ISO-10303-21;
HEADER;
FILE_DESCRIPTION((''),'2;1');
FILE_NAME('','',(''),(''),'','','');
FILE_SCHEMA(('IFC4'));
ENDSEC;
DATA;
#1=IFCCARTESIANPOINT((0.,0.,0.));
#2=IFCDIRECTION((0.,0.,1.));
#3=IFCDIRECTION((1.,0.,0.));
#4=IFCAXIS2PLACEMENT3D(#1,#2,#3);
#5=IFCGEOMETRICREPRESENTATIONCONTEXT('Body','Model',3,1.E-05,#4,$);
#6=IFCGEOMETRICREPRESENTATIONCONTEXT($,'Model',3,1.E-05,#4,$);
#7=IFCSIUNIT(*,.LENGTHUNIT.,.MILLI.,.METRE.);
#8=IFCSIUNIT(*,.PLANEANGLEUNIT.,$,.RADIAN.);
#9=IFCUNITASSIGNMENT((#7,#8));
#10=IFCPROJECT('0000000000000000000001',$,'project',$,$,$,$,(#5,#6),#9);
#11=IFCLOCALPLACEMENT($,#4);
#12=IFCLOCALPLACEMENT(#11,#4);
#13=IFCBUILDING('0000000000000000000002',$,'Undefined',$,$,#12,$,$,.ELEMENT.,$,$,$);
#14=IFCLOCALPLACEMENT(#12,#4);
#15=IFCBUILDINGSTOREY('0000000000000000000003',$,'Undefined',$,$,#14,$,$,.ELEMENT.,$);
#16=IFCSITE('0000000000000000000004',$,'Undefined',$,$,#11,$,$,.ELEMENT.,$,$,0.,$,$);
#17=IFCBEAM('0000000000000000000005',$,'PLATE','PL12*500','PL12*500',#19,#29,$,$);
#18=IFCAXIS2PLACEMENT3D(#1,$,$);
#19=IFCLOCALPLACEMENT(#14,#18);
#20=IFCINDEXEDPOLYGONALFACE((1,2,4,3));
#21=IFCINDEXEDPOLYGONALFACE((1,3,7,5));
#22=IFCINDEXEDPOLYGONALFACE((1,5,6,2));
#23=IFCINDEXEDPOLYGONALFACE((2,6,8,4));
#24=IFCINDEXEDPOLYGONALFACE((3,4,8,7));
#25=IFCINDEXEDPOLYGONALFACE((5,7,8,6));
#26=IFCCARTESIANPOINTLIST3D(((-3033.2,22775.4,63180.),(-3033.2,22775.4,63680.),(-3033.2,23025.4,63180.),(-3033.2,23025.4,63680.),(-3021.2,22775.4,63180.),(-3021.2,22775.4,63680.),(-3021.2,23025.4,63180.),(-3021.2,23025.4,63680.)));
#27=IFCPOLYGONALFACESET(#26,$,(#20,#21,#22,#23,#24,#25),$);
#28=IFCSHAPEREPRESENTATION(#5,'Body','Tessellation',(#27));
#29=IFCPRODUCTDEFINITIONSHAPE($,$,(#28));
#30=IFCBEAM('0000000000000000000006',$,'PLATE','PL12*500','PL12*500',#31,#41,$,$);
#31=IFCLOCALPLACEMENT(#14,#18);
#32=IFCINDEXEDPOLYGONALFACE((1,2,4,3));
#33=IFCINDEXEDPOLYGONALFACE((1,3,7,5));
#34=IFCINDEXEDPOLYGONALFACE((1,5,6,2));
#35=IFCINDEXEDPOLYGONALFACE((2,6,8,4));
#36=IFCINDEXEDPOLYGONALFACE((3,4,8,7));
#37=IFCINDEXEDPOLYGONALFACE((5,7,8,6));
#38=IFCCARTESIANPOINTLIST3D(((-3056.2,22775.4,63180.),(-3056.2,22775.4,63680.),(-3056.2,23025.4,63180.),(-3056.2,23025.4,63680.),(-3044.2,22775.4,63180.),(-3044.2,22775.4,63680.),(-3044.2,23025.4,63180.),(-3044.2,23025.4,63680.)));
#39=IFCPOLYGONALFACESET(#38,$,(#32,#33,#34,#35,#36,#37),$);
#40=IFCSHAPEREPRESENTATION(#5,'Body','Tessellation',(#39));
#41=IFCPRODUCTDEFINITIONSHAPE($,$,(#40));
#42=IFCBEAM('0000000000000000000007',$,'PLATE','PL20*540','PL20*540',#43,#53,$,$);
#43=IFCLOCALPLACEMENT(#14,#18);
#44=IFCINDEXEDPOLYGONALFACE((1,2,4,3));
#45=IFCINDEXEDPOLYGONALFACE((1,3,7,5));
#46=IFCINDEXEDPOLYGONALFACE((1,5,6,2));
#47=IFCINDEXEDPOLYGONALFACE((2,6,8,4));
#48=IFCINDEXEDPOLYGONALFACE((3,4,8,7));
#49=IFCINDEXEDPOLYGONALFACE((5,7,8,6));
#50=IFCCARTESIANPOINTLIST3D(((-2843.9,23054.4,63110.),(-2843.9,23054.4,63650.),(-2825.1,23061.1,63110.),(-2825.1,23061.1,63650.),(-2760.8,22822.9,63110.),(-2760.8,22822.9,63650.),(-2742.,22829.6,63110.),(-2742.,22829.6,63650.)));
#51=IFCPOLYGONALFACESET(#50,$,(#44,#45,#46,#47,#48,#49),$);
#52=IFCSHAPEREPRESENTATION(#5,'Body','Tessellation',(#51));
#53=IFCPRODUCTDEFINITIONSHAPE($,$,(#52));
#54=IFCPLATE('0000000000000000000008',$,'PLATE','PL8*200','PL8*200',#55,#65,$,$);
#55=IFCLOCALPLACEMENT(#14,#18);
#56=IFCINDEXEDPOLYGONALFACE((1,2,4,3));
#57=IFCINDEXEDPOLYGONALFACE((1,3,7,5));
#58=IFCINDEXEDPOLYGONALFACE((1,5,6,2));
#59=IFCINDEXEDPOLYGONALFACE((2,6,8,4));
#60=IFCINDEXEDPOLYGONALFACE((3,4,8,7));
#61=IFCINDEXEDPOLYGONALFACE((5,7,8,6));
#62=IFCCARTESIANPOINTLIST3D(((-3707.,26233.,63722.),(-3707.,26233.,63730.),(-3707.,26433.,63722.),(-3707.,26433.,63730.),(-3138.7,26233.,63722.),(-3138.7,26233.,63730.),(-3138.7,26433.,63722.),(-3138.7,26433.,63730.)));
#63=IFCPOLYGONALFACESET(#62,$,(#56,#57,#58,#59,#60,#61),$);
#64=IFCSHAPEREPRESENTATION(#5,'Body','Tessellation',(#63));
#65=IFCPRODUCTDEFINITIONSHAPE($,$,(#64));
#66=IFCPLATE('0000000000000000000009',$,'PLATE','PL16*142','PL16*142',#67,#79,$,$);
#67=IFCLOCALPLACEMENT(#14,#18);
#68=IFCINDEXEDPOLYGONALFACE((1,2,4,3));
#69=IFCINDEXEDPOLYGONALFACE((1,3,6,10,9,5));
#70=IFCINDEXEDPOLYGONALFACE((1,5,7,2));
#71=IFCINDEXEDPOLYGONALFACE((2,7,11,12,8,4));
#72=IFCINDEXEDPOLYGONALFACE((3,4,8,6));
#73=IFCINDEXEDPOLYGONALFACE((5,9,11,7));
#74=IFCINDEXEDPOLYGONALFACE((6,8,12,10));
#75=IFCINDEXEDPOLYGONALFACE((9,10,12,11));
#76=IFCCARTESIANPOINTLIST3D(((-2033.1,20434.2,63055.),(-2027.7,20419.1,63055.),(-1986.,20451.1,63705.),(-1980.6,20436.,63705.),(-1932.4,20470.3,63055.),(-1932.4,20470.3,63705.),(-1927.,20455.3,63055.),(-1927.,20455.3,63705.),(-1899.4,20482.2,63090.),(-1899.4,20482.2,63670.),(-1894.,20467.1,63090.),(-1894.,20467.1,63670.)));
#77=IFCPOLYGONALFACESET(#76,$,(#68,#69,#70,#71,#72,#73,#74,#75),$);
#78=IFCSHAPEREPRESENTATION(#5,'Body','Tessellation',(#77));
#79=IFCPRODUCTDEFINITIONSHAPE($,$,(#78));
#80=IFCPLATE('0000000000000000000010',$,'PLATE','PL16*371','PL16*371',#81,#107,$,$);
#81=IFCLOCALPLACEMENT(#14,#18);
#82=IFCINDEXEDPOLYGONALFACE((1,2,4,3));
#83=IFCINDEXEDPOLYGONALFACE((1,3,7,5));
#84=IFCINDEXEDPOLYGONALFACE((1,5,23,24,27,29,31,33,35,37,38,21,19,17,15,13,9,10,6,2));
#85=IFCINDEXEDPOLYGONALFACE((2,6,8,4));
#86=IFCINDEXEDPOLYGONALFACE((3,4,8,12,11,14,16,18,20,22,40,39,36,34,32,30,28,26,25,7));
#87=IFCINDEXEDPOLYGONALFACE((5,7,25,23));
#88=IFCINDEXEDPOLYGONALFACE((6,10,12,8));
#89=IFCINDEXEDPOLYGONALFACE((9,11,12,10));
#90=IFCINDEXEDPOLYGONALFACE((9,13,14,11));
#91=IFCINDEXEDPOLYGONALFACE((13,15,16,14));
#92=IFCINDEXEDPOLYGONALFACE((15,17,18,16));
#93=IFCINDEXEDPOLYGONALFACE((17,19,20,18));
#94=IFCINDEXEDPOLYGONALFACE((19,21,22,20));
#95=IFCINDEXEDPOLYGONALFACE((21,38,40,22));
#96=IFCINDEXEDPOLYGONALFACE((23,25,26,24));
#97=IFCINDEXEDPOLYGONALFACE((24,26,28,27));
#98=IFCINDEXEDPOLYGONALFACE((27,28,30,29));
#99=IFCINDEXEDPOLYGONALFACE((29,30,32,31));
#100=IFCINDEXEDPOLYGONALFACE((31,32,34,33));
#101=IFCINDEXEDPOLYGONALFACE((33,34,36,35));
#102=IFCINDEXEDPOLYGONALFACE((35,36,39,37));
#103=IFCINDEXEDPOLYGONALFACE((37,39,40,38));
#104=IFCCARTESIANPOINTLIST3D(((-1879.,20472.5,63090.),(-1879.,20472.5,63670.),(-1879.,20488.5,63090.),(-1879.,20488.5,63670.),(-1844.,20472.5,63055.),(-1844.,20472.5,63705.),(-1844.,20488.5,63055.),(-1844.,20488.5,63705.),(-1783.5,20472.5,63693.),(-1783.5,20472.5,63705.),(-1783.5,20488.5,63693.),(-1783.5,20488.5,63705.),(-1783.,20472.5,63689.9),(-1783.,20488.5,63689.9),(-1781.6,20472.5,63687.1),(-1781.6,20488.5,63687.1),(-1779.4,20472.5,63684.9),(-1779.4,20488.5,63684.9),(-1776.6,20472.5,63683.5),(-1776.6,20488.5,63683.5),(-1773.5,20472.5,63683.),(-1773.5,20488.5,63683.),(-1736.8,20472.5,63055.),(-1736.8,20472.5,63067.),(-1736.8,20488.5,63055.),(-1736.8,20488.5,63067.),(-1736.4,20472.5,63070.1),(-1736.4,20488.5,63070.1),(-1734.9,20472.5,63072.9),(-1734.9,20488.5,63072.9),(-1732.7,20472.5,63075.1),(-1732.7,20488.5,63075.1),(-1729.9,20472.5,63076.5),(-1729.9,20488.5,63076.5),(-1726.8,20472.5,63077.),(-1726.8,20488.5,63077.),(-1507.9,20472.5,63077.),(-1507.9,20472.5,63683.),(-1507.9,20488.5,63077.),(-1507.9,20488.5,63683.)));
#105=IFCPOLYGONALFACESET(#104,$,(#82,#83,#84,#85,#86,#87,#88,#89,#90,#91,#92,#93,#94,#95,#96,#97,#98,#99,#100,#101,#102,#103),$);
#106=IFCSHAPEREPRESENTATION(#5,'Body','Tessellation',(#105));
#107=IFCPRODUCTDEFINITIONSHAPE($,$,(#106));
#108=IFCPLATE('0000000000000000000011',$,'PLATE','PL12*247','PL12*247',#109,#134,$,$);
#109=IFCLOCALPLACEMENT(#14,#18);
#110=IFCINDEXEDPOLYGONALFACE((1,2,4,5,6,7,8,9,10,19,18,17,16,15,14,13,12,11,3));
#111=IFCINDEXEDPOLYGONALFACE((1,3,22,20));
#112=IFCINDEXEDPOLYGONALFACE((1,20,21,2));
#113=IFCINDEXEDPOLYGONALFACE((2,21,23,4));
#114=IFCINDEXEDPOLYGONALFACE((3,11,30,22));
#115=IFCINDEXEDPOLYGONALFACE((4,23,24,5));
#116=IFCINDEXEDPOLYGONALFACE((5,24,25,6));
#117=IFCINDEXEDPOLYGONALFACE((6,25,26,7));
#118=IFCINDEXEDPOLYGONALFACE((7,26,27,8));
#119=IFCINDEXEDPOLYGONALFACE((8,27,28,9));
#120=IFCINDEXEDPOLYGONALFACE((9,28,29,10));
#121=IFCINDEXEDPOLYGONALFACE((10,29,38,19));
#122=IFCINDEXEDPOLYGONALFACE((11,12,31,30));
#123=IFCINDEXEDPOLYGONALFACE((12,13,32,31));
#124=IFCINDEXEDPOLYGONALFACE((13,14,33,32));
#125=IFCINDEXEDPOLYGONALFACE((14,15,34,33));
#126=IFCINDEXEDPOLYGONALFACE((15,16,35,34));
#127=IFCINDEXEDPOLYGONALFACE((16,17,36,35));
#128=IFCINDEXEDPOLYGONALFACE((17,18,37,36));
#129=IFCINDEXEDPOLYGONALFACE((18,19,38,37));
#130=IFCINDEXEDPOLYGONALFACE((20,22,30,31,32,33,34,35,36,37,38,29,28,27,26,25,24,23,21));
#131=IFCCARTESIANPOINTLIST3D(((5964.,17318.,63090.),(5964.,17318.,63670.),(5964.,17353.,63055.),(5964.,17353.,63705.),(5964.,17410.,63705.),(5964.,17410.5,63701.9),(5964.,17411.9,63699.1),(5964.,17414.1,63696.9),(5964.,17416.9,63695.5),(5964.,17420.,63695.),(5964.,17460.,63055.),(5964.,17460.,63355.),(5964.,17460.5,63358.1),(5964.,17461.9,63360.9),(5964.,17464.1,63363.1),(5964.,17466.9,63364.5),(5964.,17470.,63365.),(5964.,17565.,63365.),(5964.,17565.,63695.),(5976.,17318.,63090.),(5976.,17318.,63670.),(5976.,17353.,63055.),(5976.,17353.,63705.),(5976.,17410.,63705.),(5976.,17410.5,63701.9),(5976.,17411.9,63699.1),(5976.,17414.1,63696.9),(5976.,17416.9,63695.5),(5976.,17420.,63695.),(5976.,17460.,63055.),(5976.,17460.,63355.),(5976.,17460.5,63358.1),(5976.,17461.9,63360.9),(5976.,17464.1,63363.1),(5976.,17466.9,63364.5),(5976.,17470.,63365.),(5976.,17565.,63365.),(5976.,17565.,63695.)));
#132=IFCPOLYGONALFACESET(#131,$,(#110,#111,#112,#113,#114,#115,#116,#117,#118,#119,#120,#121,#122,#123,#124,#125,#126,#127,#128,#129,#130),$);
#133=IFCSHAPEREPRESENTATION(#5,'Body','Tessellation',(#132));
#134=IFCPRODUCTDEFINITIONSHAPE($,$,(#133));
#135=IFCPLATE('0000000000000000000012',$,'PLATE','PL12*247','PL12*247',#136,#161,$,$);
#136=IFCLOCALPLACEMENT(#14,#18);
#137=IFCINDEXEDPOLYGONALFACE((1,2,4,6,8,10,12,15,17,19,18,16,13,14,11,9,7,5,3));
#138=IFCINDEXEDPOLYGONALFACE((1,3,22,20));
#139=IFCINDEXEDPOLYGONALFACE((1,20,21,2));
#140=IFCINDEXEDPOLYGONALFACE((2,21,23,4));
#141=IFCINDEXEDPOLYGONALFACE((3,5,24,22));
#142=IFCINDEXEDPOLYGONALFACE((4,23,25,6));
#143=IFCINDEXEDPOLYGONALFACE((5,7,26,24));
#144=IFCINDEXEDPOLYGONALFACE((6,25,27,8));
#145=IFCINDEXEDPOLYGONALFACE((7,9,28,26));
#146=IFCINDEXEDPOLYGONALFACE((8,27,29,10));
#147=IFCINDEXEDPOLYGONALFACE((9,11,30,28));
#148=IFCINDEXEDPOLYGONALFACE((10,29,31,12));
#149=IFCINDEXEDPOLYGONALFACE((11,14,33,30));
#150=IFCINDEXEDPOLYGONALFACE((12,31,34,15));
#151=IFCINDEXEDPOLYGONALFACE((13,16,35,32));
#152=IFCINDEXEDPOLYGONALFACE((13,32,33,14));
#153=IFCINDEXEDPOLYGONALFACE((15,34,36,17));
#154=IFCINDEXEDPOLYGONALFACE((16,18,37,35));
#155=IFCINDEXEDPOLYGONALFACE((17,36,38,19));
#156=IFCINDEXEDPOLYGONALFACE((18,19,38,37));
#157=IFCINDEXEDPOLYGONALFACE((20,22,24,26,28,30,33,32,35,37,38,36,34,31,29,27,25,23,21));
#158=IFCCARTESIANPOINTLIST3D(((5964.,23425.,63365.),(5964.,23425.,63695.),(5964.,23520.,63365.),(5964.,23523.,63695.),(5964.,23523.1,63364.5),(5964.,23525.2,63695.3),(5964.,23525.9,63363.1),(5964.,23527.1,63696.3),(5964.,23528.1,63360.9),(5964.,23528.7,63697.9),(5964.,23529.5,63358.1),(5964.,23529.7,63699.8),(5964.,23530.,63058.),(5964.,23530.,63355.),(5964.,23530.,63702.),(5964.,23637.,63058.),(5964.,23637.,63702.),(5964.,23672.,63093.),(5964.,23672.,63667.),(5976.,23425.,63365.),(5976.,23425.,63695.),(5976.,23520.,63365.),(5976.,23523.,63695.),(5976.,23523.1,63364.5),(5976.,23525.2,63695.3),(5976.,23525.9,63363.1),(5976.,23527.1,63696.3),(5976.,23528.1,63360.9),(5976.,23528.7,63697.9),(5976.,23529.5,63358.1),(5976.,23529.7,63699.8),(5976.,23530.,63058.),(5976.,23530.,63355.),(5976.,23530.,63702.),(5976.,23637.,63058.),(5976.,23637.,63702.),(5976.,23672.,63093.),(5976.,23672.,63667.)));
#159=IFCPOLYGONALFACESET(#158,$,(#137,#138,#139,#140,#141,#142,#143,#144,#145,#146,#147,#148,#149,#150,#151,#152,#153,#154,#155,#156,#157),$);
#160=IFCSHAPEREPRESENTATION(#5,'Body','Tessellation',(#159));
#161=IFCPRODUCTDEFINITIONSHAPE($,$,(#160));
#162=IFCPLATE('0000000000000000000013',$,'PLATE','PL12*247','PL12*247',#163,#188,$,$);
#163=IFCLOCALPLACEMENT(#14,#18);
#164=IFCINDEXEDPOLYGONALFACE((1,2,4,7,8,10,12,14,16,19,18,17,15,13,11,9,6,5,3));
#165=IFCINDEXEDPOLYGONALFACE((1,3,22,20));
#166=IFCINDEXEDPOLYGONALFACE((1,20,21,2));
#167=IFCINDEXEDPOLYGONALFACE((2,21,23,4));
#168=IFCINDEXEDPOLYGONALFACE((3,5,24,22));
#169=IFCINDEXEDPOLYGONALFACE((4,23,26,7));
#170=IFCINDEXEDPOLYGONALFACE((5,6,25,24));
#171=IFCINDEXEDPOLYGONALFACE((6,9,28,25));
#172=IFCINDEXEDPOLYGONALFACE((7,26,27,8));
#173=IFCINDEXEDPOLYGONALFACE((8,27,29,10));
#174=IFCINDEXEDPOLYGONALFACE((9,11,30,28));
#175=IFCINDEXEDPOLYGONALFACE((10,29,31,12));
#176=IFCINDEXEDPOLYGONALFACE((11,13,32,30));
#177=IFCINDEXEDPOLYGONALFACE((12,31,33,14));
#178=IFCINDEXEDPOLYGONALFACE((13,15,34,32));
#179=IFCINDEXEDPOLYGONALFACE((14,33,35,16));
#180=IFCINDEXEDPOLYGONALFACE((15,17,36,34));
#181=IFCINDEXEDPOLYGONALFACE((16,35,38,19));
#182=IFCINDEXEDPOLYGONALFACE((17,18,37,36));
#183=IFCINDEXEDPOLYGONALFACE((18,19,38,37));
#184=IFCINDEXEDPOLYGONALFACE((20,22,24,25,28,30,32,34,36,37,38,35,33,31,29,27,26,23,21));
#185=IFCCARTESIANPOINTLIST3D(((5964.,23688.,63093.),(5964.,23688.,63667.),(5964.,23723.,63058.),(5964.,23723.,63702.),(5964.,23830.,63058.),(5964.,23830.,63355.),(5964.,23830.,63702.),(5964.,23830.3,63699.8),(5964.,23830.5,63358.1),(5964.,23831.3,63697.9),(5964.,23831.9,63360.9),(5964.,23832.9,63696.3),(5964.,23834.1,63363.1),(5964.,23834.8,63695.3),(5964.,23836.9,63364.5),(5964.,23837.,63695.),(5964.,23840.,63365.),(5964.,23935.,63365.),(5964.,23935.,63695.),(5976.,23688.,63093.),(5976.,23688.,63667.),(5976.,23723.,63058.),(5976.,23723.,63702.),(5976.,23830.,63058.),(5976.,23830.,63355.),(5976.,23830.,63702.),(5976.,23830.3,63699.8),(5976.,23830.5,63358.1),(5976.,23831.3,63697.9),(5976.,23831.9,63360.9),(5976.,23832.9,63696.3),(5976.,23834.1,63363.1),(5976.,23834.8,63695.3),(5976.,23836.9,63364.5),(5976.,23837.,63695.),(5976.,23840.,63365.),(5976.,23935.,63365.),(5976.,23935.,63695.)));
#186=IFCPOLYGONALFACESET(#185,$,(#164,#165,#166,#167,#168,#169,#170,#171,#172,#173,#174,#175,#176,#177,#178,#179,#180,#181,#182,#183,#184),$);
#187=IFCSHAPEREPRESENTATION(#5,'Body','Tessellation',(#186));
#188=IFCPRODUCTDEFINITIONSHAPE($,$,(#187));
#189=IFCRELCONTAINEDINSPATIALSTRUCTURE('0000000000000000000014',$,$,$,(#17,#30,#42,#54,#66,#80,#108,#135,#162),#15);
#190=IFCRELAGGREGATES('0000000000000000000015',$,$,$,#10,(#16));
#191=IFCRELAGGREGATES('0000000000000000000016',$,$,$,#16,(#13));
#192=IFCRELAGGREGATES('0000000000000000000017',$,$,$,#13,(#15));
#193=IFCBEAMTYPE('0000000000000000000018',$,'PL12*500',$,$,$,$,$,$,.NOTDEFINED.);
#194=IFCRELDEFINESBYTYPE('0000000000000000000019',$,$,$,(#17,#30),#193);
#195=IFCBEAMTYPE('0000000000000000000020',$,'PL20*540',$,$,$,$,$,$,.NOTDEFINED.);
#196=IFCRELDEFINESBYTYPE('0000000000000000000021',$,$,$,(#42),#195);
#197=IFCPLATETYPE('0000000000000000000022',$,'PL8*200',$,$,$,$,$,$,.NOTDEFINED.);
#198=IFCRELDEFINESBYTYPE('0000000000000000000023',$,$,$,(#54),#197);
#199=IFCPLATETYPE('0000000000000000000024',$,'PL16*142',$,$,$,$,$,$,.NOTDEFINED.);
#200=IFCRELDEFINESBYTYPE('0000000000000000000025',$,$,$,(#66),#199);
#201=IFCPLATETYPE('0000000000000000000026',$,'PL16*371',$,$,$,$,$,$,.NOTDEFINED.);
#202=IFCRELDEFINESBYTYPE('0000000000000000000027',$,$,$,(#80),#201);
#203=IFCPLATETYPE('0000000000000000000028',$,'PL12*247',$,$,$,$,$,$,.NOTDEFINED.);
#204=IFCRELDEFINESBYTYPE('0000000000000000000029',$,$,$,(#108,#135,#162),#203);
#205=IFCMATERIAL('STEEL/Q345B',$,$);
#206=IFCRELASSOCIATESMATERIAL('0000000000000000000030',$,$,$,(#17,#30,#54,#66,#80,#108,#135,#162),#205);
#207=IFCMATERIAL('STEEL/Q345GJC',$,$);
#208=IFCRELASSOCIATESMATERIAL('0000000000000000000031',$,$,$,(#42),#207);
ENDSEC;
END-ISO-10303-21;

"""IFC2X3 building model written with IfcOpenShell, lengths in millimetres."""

from ifc_helpers import new_model, si_unit, frame, origin_with_axes, origin_2d_with_axis, place, context, project, spatial, polyline, rectangle, outline, extrude, material, type_object, element, save


model = new_model("IFC2X3")

# Units and contexts
model_context_1 = context("Model", 3, precision=1e-05, world=origin_with_axes(), identifier="Body")
model_context_2 = context("Model", 3, precision=1e-05, world=origin_with_axes())
ifc_project = project(units=[si_unit("LENGTHUNIT", "METRE", prefix="MILLI"), si_unit("PLANEANGLEUNIT", "RADIAN")], contexts=[model_context_1, model_context_2])

# Site, building, storey
site_placement = place(None, origin_with_axes())
site = spatial("IfcSite", under=ifc_project, at=site_placement, Name="Undefined", CompositionType="ELEMENT", RefElevation=0.0)
building_placement = place(site_placement, origin_with_axes())
building = spatial("IfcBuilding", under=site, at=building_placement, Name="Undefined", CompositionType="ELEMENT")
storey_placement = place(building_placement, origin_with_axes())
storey = spatial("IfcBuildingStorey", under=building, at=storey_placement, Name="Undefined", CompositionType="ELEMENT")

# Shared definitions
ifc_material_1 = material(Name="STEEL/Q345B")

# Beams
beam_type_1 = type_object("IfcBeamType", Name="PL12*500", PredefinedType="NOTDEFINED")
for number, where, z_axis, x_axis, name in (
    (1, (-3027.2, 23025.4, 63430.0), (0.0, 0.0, 1.0), (0.0, -1.0, 0.0), "PLATE"),
    (2, (-3050.2, 23025.4, 63430.0), (0.0, 0.0, 1.0), (0.0, -1.0, 0.0), "PLATE"),
):
    element("IfcBeam", number, at=place(storey_placement, frame(where, z_axis=z_axis, x_axis=x_axis)), inside=storey, type_object=beam_type_1, material=ifc_material_1, Name=name, Description="PL12*500", ObjectType="PL12*500", context=model_context_1, shape_type="SweptSolid", body=[
        extrude(rectangle(XDim=12.0, YDim=500.0, at=origin_2d_with_axis()), frame((250.0, 0.0, 0.0), z_axis=(-1.0, 0.0, 0.0), x_axis=(0.0, -1.0, 0.0)), (0.0, 0.0, 1.0), 250.0),
    ])
ifc_material_2 = material(Name="STEEL/Q345GJC")
beam_type_2 = type_object("IfcBeamType", Name="PL20*540", PredefinedType="NOTDEFINED")
beam_1_placement = place(storey_placement, frame((-2834.5, 23057.8, 63380.0), z_axis=(0.0, 0.0, 1.0), x_axis=(0.337816, -0.941212, 0.0)))
element("IfcBeam", 3, at=beam_1_placement, inside=storey, type_object=beam_type_2, material=ifc_material_2, Name="PLATE", Description="PL20*540", ObjectType="PL20*540", context=model_context_1, shape_type="SweptSolid", body=[
    extrude(rectangle(XDim=20.0, YDim=540.0, at=origin_2d_with_axis()), frame((246.0, 0.0, 0.0), z_axis=(-1.0, 0.0, 0.0), x_axis=(0.0, -1.0, 0.0)), (0.0, 0.0, 1.0), 246.0),
])

# Plates
plate_type_1 = type_object("IfcPlateType", Name="PL8*200", PredefinedType="NOTDEFINED")
plate_1_placement = place(storey_placement, frame((-3707.0, 26233.0, 63726.0), z_axis=(0.0, 0.0, 1.0), x_axis=(1.0, 0.0, 0.0)))
element("IfcPlate", 4, at=plate_1_placement, inside=storey, type_object=plate_type_1, material=ifc_material_1, Name="PLATE", Description="PL8*200", ObjectType="PL8*200", context=model_context_1, shape_type="SweptSolid", body=[
    extrude(outline(polyline([(0.0, 0.0), (568.3, 0.0), (568.3, 200.0), (0.0, 200.0), (0.0, 0.0)])), frame((0.0, 0.0, -4.0), z_axis=(0.0, 0.0, 1.0), x_axis=(1.0, 0.0, 0.0)), (0.0, 0.0, 1.0), 8.0),
])
plate_type_2 = type_object("IfcPlateType", Name="PL16*142", PredefinedType="NOTDEFINED")
plate_2_placement = place(storey_placement, frame((-1896.7, 20474.6, 63705.0), z_axis=(0.337816, -0.941212, 0.0), x_axis=(-0.941212, -0.337816, 0.0)))
element("IfcPlate", 5, at=plate_2_placement, inside=storey, type_object=plate_type_2, material=ifc_material_1, Name="PLATE", Description="PL16*142", ObjectType="PL16*142", context=model_context_1, shape_type="SweptSolid", body=[
    extrude(outline(polyline([(0.0, 35.0), (35.0, 0.0), (92.0, 0.0), (142.0, 650.0), (35.0, 650.0), (0.0, 615.0), (0.0, 35.0)])), frame((0.0, 0.0, -8.0), z_axis=(0.0, 0.0, 1.0), x_axis=(1.0, 0.0, 0.0)), (0.0, 0.0, 1.0), 16.0),
])
plate_type_3 = type_object("IfcPlateType", Name="PL16*371", PredefinedType="NOTDEFINED")
plate_3_placement = place(storey_placement, frame((-1783.5, 20480.5, 63705.0), z_axis=(0.0, -1.0, 0.0), x_axis=(-1.0, 0.0, 0.0)))
element("IfcPlate", 6, at=plate_3_placement, inside=storey, type_object=plate_type_3, material=ifc_material_1, Name="PLATE", Description="PL16*371", ObjectType="PL16*371", context=model_context_1, shape_type="SweptSolid", body=[
    extrude(outline(polyline([(0.0, 0.0), (60.5, 0.0), (95.5, 35.0), (95.5, 615.0), (60.5, 650.0), (-46.7, 650.0), (-46.7, 638.0), (-47.2, 634.9), (-48.6, 632.1), (-50.8, 629.9), (-53.6, 628.5), (-56.7, 628.0), (-275.6, 628.0), (-275.6, 22.0), (-10.0, 22.0), (-6.9, 21.5), (-4.1, 20.1), (-1.9, 17.9), (-0.5, 15.1), (0.0, 12.0), (0.0, 0.0)])), frame((0.0, 0.0, -8.0), z_axis=(0.0, 0.0, 1.0), x_axis=(1.0, 0.0, 0.0)), (0.0, 0.0, 1.0), 16.0),
])
plate_type_4 = type_object("IfcPlateType", Name="PL12*247", PredefinedType="NOTDEFINED")
plate_4_placement = place(storey_placement, frame((5970.0, 17318.0, 63090.0), z_axis=(1.0, 0.0, 0.0), x_axis=(0.0, 0.707107, -0.707107)))
element("IfcPlate", 7, at=plate_4_placement, inside=storey, type_object=plate_type_4, material=ifc_material_1, Name="PLATE", Description="PL12*247", ObjectType="PL12*247", context=model_context_1, shape_type="SweptSolid", body=[
    extrude(outline(polyline([(0.0, 0.0), (49.5, 0.0), (125.2, 75.7), (-87.0, 287.8), (-88.8, 290.3), (-89.8, 293.3), (-89.8, 296.4), (-88.8, 299.4), (-87.0, 301.9), (-19.8, 369.1), (-253.1, 602.5), (-355.7, 499.9), (-358.2, 498.1), (-361.2, 497.1), (-364.3, 497.1), (-367.3, 498.1), (-369.8, 499.9), (-410.1, 459.6), (-410.1, 410.1), (0.0, 0.0)])), frame((0.0, 0.0, -6.0), z_axis=(0.0, 0.0, 1.0), x_axis=(1.0, 0.0, 0.0)), (0.0, 0.0, 1.0), 12.0),
])
for number, where, z_axis, x_axis, name in (
    (8, (5970.0, 23672.0, 63093.0), (-1.0, 0.0, 0.0), (0.0, -0.707107, -0.707107), "PLATE"),
    (9, (5970.0, 23688.0, 63093.0), (1.0, 0.0, 0.0), (0.0, 0.707107, -0.707107), "PLATE"),
):
    element("IfcPlate", number, at=place(storey_placement, frame(where, z_axis=z_axis, x_axis=x_axis)), inside=storey, type_object=plate_type_4, material=ifc_material_1, Name=name, Description="PL12*247", ObjectType="PL12*247", context=model_context_1, shape_type="SweptSolid", body=[
        extrude(outline(polyline([(0.0, 0.0), (49.5, 0.0), (125.2, 75.7), (-84.9, 285.7), (-86.7, 288.2), (-87.7, 291.2), (-87.7, 294.3), (-86.7, 297.3), (-84.9, 299.8), (-17.7, 367.0), (-251.0, 600.3), (-320.3, 531.0), (-322.1, 529.7), (-324.2, 529.1), (-326.4, 529.1), (-328.4, 529.7), (-330.2, 531.0), (-405.9, 455.4), (-405.9, 405.9), (0.0, 0.0)])), frame((0.0, 0.0, -6.0), z_axis=(0.0, 0.0, 1.0), x_axis=(1.0, 0.0, 0.0)), (0.0, 0.0, 1.0), 12.0),
    ])

save(model, "model.ifc")
